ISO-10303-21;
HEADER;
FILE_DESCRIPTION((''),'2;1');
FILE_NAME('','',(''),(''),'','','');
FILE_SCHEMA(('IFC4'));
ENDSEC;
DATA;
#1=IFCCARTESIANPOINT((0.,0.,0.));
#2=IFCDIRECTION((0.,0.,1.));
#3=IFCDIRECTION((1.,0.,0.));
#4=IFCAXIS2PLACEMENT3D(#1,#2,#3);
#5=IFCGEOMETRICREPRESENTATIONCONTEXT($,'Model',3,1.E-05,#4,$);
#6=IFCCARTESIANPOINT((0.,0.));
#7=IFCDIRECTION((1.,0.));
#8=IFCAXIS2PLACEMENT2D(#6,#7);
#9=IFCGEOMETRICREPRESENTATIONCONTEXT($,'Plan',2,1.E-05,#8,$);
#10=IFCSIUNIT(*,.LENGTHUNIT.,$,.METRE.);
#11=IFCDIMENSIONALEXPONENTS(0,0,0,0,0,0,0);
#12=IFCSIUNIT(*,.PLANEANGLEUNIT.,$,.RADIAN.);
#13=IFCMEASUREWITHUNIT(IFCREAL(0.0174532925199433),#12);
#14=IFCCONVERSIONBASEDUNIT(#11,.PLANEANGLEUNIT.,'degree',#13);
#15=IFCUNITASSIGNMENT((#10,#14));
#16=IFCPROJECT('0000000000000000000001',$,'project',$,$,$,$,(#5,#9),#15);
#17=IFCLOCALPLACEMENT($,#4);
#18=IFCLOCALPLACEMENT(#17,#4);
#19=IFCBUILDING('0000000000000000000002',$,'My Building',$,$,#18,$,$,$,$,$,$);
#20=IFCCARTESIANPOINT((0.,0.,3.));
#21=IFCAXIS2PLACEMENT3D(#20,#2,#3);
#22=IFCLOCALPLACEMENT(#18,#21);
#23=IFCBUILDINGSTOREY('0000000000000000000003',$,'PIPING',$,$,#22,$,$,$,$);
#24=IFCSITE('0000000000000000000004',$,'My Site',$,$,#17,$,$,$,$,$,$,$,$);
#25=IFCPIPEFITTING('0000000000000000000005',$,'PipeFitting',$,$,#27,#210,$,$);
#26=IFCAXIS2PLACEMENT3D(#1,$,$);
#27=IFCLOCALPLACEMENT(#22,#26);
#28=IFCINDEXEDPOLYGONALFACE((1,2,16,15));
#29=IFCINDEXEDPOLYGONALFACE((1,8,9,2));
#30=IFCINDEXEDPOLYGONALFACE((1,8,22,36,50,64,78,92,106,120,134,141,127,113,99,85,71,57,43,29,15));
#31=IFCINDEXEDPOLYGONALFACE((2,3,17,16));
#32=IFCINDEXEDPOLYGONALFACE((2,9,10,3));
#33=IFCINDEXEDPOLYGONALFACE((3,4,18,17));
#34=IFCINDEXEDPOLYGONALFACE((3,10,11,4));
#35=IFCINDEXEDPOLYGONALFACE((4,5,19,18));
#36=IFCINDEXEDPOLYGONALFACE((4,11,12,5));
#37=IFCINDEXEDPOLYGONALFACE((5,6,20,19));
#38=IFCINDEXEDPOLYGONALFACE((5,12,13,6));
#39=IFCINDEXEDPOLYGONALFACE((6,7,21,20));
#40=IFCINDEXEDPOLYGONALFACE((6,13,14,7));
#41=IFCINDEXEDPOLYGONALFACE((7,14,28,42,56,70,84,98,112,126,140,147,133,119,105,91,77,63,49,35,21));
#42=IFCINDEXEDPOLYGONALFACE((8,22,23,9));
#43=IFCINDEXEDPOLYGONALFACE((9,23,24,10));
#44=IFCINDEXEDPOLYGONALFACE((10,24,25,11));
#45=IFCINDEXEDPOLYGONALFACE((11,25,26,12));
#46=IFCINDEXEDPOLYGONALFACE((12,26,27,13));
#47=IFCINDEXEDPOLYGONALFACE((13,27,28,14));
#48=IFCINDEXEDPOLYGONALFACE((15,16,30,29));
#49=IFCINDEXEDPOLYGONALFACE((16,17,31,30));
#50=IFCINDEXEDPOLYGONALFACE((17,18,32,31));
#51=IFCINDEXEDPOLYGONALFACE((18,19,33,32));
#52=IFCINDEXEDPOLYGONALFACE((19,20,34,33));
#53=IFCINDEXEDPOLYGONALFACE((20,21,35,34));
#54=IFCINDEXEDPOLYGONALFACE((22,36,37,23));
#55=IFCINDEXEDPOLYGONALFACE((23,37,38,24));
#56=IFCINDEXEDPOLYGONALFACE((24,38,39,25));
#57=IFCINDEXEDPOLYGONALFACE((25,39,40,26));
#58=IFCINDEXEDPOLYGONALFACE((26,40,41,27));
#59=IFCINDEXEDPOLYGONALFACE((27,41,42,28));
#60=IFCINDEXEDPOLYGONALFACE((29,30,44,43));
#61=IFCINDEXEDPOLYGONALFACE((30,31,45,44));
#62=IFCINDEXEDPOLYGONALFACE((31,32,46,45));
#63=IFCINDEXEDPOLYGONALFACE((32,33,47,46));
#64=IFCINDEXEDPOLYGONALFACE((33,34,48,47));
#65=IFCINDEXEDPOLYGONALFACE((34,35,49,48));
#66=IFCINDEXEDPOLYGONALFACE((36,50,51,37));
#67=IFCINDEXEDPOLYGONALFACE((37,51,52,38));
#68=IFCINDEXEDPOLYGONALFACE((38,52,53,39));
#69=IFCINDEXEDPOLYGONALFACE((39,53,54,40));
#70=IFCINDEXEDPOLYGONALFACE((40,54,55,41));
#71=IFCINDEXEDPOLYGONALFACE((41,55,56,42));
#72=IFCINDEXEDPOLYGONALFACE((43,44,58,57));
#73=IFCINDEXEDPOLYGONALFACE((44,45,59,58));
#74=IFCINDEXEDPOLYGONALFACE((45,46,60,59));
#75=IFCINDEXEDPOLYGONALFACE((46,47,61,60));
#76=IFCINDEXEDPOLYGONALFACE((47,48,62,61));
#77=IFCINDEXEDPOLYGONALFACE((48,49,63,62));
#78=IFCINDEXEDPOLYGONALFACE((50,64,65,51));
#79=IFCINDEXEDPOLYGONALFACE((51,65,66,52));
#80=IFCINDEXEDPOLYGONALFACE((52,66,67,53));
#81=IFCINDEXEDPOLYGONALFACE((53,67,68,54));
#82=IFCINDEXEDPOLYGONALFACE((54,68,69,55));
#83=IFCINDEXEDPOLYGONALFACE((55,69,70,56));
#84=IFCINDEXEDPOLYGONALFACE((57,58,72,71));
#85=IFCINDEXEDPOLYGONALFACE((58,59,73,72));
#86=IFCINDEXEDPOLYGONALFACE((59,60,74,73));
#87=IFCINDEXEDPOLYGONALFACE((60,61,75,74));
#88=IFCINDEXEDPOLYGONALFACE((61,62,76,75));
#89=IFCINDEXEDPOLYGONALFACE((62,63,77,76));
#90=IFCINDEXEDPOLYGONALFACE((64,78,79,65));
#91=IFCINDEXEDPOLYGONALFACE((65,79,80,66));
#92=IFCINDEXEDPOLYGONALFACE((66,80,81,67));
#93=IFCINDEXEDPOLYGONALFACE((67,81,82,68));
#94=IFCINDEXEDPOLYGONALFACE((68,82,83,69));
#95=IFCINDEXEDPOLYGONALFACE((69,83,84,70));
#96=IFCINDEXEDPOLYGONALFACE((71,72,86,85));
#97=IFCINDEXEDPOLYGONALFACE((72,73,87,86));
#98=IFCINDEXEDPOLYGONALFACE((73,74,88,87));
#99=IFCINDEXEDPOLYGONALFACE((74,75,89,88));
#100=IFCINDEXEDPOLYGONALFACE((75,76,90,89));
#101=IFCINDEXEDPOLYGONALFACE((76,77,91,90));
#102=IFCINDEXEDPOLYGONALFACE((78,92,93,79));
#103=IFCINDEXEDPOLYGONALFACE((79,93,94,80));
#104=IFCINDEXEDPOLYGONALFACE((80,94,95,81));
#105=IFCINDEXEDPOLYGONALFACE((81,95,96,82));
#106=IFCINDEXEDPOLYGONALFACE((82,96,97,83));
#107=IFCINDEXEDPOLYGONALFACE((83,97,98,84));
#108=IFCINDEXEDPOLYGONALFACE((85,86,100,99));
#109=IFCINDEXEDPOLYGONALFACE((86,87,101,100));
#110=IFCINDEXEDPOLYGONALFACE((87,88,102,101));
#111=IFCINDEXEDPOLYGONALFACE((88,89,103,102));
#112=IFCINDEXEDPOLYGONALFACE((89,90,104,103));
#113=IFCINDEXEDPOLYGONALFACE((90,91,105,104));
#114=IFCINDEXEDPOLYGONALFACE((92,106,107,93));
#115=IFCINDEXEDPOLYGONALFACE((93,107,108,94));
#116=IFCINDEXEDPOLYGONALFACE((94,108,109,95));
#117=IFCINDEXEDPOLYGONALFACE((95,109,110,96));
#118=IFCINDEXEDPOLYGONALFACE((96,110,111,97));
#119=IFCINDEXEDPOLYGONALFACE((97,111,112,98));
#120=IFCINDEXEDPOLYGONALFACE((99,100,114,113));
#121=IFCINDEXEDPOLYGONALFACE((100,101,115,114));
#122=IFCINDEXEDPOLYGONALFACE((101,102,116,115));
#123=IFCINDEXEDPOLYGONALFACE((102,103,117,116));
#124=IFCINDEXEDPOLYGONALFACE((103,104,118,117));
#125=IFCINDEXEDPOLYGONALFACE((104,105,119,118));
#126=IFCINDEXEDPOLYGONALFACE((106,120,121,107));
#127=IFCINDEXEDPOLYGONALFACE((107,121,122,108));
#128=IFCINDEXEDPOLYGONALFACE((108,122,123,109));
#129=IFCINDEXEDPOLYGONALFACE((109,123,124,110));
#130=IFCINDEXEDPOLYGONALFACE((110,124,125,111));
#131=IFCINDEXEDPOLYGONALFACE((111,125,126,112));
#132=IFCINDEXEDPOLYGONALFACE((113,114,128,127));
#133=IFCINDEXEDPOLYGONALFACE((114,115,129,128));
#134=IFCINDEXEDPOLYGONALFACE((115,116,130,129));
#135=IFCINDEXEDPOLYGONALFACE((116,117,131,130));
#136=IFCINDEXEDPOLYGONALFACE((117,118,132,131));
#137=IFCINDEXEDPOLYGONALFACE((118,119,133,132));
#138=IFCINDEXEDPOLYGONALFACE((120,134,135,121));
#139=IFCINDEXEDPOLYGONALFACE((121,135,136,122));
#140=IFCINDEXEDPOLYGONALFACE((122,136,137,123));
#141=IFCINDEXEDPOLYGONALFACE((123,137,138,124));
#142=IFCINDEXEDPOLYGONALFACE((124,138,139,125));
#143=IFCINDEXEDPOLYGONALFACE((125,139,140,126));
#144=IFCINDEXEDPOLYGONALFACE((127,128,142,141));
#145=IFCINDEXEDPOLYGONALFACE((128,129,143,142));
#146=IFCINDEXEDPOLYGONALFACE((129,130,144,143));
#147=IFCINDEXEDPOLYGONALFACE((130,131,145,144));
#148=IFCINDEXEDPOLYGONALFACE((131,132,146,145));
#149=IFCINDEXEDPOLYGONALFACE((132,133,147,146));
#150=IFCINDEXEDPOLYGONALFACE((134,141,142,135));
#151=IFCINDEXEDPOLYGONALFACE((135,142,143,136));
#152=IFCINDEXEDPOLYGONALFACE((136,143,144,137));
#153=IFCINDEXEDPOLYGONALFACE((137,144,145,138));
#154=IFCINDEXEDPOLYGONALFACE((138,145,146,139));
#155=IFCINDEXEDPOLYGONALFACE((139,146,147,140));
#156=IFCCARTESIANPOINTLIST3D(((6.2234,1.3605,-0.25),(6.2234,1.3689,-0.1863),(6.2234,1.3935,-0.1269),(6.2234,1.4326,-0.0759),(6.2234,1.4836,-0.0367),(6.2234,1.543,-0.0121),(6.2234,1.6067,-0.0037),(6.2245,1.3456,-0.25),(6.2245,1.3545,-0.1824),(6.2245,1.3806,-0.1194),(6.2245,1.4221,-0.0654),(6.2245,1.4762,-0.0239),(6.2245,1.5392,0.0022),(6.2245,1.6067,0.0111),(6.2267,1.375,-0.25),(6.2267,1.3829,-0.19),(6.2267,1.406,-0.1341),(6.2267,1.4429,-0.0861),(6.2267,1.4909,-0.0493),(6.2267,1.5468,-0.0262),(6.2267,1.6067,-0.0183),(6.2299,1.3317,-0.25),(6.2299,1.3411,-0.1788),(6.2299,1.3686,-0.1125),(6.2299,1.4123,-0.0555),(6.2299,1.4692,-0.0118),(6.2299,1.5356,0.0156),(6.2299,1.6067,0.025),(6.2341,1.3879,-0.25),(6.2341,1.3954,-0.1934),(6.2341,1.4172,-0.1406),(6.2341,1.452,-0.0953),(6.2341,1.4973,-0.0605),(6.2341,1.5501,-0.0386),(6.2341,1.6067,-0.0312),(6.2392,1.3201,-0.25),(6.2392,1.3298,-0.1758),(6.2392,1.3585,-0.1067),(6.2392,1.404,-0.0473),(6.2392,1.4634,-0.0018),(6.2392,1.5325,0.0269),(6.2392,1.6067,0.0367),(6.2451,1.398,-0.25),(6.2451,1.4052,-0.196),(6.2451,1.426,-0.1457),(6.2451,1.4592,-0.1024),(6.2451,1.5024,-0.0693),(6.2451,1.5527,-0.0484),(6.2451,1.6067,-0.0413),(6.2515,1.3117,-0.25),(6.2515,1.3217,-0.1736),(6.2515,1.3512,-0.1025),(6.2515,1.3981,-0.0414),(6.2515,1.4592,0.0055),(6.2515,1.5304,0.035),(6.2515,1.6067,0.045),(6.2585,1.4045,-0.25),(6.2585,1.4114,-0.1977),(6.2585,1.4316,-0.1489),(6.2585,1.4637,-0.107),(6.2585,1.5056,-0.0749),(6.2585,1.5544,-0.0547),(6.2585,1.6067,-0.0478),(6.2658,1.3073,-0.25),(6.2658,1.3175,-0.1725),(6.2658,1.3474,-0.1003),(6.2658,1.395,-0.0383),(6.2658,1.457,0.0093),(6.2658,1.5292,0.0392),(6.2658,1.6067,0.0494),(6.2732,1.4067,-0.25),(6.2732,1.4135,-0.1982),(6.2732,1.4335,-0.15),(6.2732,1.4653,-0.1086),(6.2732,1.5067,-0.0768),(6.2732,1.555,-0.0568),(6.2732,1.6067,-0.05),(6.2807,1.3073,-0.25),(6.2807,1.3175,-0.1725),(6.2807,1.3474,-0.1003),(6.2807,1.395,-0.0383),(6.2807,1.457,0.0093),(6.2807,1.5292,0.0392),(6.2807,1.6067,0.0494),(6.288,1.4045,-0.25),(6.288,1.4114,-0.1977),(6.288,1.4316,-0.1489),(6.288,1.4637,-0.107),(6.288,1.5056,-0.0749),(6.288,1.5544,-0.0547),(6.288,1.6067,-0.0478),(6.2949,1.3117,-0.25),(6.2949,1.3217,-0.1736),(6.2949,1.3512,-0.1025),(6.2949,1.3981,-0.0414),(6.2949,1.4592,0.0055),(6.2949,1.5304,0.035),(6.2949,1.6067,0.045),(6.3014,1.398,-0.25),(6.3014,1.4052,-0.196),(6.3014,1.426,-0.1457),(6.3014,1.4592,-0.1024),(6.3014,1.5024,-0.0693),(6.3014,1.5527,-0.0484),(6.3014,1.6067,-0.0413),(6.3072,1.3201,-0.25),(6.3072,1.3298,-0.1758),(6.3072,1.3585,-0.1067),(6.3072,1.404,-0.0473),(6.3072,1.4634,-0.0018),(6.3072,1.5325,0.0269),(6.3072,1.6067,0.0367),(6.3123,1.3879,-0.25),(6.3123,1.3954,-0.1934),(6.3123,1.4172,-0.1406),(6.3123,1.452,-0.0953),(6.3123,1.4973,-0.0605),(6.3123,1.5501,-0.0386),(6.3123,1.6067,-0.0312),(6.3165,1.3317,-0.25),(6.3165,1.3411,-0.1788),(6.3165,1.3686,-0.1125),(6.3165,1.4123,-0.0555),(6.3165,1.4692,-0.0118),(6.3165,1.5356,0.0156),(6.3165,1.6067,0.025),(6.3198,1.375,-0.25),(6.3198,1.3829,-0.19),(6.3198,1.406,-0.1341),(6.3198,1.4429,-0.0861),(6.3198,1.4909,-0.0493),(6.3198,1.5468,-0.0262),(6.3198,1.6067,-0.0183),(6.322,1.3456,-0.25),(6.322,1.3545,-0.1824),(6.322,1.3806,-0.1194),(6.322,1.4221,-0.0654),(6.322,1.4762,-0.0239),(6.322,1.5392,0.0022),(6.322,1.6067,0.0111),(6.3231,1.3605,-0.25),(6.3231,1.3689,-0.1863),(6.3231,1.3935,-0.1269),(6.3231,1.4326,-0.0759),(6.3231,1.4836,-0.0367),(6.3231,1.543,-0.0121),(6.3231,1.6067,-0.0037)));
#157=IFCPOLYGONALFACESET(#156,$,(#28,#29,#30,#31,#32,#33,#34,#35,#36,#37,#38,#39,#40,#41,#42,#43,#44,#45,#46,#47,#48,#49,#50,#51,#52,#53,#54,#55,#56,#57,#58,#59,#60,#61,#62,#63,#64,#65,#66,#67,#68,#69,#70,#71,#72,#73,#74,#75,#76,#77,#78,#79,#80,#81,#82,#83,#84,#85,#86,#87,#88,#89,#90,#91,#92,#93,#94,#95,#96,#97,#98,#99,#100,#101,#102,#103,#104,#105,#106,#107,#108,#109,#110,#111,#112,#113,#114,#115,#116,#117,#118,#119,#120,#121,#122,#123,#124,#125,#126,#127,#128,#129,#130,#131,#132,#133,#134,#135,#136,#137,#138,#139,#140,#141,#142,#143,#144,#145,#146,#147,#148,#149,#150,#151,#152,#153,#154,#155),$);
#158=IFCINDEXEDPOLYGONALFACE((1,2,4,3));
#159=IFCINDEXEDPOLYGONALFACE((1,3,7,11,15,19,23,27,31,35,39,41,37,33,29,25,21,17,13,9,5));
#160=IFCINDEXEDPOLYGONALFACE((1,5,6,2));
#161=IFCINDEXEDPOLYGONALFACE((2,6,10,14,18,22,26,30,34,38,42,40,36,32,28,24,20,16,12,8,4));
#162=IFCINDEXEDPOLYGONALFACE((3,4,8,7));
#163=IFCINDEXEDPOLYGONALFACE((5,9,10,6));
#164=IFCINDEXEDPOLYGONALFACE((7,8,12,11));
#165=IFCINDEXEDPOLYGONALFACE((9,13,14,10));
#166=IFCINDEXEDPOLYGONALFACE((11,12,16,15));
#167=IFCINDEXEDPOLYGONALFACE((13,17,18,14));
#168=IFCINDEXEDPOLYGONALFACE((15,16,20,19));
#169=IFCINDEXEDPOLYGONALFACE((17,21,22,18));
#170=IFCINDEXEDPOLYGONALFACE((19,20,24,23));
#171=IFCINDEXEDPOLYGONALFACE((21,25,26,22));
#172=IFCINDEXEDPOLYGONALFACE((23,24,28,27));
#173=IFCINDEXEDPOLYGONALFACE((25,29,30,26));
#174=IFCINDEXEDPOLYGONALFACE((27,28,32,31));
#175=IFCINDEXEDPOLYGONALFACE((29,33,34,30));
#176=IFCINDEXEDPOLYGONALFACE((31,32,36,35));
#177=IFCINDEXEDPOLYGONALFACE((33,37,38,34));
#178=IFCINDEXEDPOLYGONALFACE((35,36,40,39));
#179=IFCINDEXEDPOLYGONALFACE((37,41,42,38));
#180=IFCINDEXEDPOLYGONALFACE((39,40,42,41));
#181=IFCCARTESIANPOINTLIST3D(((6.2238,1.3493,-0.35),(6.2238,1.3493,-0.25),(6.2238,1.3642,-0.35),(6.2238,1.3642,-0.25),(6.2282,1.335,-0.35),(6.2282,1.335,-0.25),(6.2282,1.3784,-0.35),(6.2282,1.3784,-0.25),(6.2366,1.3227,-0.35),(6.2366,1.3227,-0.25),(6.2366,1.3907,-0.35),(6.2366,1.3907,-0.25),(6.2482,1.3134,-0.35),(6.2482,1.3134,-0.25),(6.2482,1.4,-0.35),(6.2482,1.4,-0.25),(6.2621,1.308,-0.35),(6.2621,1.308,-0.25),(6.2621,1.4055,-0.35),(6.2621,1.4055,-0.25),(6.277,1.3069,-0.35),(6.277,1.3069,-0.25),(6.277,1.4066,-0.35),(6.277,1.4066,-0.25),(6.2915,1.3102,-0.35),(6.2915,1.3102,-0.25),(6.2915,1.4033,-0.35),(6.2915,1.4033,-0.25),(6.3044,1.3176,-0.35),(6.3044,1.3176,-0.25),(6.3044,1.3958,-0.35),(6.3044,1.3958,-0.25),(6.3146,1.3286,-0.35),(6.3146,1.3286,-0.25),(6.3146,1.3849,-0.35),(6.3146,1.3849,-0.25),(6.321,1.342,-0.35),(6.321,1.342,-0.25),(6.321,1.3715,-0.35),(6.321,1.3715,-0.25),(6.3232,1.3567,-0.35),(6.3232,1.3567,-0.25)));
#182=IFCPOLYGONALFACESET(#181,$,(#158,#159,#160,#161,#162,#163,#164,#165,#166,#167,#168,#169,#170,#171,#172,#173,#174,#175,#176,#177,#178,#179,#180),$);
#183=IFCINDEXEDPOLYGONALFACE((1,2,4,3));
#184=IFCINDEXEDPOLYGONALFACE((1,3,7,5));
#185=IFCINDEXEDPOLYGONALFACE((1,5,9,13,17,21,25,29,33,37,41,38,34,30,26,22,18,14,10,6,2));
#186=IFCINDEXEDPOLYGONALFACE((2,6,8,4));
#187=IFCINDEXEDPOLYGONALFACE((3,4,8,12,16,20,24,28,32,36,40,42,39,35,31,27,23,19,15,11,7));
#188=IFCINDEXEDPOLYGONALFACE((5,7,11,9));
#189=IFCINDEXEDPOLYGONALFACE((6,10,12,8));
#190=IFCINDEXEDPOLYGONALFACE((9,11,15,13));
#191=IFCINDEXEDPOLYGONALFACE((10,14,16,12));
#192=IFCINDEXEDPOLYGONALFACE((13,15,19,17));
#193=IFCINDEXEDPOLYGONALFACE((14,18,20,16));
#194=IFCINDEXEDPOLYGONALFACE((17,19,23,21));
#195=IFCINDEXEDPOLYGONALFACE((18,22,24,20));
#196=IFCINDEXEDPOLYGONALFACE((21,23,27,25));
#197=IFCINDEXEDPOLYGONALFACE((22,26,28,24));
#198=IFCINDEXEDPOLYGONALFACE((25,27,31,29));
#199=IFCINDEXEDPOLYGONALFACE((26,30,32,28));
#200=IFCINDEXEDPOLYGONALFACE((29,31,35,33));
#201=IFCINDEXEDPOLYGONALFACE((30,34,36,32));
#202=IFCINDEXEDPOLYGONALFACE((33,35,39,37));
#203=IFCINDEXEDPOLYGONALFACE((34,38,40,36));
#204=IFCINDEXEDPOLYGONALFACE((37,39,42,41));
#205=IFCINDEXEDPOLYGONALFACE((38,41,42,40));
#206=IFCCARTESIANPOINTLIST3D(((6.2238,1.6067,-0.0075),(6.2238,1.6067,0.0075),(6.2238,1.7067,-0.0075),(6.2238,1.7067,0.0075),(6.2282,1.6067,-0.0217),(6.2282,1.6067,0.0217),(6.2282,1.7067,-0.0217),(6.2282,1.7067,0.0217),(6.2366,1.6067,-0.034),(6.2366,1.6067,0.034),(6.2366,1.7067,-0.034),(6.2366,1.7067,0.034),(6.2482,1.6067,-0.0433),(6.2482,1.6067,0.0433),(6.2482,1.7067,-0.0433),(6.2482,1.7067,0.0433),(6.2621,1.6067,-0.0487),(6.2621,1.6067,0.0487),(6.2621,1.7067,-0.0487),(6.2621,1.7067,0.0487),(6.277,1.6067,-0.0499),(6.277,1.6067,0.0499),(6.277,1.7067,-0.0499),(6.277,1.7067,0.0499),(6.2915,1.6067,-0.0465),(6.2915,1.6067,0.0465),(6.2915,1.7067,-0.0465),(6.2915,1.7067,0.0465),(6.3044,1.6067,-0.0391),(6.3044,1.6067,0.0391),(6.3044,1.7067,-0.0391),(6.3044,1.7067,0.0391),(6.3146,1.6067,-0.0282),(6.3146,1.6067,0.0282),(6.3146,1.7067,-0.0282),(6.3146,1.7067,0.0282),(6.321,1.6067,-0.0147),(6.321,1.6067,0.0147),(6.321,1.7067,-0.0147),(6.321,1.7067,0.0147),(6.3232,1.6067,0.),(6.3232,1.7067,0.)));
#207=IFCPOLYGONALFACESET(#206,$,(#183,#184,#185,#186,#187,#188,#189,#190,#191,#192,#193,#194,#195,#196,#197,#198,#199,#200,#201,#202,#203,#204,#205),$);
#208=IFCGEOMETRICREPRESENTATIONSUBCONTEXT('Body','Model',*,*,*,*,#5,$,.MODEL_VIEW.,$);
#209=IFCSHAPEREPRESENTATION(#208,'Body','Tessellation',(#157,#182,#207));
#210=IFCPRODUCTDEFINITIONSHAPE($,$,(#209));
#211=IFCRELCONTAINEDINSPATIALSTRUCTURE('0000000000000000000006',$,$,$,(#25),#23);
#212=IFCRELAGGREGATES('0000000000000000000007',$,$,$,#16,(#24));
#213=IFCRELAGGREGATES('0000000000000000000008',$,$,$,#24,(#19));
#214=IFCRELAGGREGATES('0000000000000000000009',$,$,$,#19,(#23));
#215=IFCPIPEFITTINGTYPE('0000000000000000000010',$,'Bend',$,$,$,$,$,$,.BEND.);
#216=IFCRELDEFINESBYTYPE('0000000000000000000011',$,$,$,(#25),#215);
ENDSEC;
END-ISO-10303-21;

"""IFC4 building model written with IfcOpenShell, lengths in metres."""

from ifc_helpers import new_model, entity, si_unit, converted_unit, frame, origin_with_axes, origin_2d_with_axis, place, context, subcontext, project, spatial, circle, extrude, source, transform, mapped, type_object, type_shapes, element, save


model = new_model("IFC4")

# Units and contexts
model_context = context("Model", 3, precision=1e-05, world=origin_with_axes())
plan_context = context("Plan", 2, precision=1e-05, world=origin_2d_with_axis())
body_context = subcontext(model_context, "Body", "Model", "MODEL_VIEW")
ifc_project = project(units=[si_unit("LENGTHUNIT", "METRE"), converted_unit("PLANEANGLEUNIT", "degree", entity("IfcReal", 0.0174532925199433), si_unit("PLANEANGLEUNIT", "RADIAN"), dimensions=[0, 0, 0, 0, 0, 0, 0])], contexts=[model_context, plan_context])

# Site, building, storey
site_placement = place(None, origin_with_axes())
site = spatial("IfcSite", under=ifc_project, at=site_placement, Name="My Site")
building_placement = place(site_placement, origin_with_axes())
building = spatial("IfcBuilding", under=site, at=building_placement, Name="My Building")
storey_placement = place(building_placement, frame((0.0, 0.0, 3.0), z_axis=(0.0, 0.0, 1.0), x_axis=(1.0, 0.0, 0.0)))
storey = spatial("IfcBuildingStorey", under=building, at=storey_placement, Name="PIPING")

# Pipe fitting
pipe_fitting_type_1 = type_object("IfcPipeFittingType", Name="Bend", PredefinedType="BEND")
shared_shape = source(origin_with_axes(), body_context, "Body", "SolidModel", [
    entity("IfcSweptDiskSolid", entity("IfcIndexedPolyCurve", entity("IfcCartesianPointList3D", [[0.0, 0.0, -0.1], [0.0, -0.0732, -0.2768], [0.0, -0.25, -0.35]]), [entity("IfcArcIndex", [1, 2, 3])]), 0.05),
    extrude(circle(Radius=0.05), origin_with_axes(), (0.0, 0.0, -1.0), 0.1),
    extrude(circle(Radius=0.05), frame((0.0, -0.25, -0.35), z_axis=(0.0, -1.0, 0.0), x_axis=(1.0, 0.0, 0.0)), (0.0, 0.0, 1.0), 0.1),
])
type_shapes(pipe_fitting_type_1, [shared_shape])
for number, where, z_axis, x_axis, name in (
    (1, (6.2732, 1.3567, -0.35), (0.0, 0.0, -1.0), (1.0, 0.0, 0.0), "PipeFitting"),
):
    element("IfcPipeFitting", number, at=place(storey_placement, frame(where, z_axis=z_axis, x_axis=x_axis)), inside=storey, type_object=pipe_fitting_type_1, Name=name, context=body_context, shape_type="MappedRepresentation", body=[
        mapped(shared_shape, transform((0.0, 0.0, 0.0), x_axis=(1.0, 0.0, 0.0), y_axis=(0.0, 1.0, 0.0), z_axis=(0.0, 0.0, 1.0), scale=1.0)),
    ])

save(model, "model.ifc")
